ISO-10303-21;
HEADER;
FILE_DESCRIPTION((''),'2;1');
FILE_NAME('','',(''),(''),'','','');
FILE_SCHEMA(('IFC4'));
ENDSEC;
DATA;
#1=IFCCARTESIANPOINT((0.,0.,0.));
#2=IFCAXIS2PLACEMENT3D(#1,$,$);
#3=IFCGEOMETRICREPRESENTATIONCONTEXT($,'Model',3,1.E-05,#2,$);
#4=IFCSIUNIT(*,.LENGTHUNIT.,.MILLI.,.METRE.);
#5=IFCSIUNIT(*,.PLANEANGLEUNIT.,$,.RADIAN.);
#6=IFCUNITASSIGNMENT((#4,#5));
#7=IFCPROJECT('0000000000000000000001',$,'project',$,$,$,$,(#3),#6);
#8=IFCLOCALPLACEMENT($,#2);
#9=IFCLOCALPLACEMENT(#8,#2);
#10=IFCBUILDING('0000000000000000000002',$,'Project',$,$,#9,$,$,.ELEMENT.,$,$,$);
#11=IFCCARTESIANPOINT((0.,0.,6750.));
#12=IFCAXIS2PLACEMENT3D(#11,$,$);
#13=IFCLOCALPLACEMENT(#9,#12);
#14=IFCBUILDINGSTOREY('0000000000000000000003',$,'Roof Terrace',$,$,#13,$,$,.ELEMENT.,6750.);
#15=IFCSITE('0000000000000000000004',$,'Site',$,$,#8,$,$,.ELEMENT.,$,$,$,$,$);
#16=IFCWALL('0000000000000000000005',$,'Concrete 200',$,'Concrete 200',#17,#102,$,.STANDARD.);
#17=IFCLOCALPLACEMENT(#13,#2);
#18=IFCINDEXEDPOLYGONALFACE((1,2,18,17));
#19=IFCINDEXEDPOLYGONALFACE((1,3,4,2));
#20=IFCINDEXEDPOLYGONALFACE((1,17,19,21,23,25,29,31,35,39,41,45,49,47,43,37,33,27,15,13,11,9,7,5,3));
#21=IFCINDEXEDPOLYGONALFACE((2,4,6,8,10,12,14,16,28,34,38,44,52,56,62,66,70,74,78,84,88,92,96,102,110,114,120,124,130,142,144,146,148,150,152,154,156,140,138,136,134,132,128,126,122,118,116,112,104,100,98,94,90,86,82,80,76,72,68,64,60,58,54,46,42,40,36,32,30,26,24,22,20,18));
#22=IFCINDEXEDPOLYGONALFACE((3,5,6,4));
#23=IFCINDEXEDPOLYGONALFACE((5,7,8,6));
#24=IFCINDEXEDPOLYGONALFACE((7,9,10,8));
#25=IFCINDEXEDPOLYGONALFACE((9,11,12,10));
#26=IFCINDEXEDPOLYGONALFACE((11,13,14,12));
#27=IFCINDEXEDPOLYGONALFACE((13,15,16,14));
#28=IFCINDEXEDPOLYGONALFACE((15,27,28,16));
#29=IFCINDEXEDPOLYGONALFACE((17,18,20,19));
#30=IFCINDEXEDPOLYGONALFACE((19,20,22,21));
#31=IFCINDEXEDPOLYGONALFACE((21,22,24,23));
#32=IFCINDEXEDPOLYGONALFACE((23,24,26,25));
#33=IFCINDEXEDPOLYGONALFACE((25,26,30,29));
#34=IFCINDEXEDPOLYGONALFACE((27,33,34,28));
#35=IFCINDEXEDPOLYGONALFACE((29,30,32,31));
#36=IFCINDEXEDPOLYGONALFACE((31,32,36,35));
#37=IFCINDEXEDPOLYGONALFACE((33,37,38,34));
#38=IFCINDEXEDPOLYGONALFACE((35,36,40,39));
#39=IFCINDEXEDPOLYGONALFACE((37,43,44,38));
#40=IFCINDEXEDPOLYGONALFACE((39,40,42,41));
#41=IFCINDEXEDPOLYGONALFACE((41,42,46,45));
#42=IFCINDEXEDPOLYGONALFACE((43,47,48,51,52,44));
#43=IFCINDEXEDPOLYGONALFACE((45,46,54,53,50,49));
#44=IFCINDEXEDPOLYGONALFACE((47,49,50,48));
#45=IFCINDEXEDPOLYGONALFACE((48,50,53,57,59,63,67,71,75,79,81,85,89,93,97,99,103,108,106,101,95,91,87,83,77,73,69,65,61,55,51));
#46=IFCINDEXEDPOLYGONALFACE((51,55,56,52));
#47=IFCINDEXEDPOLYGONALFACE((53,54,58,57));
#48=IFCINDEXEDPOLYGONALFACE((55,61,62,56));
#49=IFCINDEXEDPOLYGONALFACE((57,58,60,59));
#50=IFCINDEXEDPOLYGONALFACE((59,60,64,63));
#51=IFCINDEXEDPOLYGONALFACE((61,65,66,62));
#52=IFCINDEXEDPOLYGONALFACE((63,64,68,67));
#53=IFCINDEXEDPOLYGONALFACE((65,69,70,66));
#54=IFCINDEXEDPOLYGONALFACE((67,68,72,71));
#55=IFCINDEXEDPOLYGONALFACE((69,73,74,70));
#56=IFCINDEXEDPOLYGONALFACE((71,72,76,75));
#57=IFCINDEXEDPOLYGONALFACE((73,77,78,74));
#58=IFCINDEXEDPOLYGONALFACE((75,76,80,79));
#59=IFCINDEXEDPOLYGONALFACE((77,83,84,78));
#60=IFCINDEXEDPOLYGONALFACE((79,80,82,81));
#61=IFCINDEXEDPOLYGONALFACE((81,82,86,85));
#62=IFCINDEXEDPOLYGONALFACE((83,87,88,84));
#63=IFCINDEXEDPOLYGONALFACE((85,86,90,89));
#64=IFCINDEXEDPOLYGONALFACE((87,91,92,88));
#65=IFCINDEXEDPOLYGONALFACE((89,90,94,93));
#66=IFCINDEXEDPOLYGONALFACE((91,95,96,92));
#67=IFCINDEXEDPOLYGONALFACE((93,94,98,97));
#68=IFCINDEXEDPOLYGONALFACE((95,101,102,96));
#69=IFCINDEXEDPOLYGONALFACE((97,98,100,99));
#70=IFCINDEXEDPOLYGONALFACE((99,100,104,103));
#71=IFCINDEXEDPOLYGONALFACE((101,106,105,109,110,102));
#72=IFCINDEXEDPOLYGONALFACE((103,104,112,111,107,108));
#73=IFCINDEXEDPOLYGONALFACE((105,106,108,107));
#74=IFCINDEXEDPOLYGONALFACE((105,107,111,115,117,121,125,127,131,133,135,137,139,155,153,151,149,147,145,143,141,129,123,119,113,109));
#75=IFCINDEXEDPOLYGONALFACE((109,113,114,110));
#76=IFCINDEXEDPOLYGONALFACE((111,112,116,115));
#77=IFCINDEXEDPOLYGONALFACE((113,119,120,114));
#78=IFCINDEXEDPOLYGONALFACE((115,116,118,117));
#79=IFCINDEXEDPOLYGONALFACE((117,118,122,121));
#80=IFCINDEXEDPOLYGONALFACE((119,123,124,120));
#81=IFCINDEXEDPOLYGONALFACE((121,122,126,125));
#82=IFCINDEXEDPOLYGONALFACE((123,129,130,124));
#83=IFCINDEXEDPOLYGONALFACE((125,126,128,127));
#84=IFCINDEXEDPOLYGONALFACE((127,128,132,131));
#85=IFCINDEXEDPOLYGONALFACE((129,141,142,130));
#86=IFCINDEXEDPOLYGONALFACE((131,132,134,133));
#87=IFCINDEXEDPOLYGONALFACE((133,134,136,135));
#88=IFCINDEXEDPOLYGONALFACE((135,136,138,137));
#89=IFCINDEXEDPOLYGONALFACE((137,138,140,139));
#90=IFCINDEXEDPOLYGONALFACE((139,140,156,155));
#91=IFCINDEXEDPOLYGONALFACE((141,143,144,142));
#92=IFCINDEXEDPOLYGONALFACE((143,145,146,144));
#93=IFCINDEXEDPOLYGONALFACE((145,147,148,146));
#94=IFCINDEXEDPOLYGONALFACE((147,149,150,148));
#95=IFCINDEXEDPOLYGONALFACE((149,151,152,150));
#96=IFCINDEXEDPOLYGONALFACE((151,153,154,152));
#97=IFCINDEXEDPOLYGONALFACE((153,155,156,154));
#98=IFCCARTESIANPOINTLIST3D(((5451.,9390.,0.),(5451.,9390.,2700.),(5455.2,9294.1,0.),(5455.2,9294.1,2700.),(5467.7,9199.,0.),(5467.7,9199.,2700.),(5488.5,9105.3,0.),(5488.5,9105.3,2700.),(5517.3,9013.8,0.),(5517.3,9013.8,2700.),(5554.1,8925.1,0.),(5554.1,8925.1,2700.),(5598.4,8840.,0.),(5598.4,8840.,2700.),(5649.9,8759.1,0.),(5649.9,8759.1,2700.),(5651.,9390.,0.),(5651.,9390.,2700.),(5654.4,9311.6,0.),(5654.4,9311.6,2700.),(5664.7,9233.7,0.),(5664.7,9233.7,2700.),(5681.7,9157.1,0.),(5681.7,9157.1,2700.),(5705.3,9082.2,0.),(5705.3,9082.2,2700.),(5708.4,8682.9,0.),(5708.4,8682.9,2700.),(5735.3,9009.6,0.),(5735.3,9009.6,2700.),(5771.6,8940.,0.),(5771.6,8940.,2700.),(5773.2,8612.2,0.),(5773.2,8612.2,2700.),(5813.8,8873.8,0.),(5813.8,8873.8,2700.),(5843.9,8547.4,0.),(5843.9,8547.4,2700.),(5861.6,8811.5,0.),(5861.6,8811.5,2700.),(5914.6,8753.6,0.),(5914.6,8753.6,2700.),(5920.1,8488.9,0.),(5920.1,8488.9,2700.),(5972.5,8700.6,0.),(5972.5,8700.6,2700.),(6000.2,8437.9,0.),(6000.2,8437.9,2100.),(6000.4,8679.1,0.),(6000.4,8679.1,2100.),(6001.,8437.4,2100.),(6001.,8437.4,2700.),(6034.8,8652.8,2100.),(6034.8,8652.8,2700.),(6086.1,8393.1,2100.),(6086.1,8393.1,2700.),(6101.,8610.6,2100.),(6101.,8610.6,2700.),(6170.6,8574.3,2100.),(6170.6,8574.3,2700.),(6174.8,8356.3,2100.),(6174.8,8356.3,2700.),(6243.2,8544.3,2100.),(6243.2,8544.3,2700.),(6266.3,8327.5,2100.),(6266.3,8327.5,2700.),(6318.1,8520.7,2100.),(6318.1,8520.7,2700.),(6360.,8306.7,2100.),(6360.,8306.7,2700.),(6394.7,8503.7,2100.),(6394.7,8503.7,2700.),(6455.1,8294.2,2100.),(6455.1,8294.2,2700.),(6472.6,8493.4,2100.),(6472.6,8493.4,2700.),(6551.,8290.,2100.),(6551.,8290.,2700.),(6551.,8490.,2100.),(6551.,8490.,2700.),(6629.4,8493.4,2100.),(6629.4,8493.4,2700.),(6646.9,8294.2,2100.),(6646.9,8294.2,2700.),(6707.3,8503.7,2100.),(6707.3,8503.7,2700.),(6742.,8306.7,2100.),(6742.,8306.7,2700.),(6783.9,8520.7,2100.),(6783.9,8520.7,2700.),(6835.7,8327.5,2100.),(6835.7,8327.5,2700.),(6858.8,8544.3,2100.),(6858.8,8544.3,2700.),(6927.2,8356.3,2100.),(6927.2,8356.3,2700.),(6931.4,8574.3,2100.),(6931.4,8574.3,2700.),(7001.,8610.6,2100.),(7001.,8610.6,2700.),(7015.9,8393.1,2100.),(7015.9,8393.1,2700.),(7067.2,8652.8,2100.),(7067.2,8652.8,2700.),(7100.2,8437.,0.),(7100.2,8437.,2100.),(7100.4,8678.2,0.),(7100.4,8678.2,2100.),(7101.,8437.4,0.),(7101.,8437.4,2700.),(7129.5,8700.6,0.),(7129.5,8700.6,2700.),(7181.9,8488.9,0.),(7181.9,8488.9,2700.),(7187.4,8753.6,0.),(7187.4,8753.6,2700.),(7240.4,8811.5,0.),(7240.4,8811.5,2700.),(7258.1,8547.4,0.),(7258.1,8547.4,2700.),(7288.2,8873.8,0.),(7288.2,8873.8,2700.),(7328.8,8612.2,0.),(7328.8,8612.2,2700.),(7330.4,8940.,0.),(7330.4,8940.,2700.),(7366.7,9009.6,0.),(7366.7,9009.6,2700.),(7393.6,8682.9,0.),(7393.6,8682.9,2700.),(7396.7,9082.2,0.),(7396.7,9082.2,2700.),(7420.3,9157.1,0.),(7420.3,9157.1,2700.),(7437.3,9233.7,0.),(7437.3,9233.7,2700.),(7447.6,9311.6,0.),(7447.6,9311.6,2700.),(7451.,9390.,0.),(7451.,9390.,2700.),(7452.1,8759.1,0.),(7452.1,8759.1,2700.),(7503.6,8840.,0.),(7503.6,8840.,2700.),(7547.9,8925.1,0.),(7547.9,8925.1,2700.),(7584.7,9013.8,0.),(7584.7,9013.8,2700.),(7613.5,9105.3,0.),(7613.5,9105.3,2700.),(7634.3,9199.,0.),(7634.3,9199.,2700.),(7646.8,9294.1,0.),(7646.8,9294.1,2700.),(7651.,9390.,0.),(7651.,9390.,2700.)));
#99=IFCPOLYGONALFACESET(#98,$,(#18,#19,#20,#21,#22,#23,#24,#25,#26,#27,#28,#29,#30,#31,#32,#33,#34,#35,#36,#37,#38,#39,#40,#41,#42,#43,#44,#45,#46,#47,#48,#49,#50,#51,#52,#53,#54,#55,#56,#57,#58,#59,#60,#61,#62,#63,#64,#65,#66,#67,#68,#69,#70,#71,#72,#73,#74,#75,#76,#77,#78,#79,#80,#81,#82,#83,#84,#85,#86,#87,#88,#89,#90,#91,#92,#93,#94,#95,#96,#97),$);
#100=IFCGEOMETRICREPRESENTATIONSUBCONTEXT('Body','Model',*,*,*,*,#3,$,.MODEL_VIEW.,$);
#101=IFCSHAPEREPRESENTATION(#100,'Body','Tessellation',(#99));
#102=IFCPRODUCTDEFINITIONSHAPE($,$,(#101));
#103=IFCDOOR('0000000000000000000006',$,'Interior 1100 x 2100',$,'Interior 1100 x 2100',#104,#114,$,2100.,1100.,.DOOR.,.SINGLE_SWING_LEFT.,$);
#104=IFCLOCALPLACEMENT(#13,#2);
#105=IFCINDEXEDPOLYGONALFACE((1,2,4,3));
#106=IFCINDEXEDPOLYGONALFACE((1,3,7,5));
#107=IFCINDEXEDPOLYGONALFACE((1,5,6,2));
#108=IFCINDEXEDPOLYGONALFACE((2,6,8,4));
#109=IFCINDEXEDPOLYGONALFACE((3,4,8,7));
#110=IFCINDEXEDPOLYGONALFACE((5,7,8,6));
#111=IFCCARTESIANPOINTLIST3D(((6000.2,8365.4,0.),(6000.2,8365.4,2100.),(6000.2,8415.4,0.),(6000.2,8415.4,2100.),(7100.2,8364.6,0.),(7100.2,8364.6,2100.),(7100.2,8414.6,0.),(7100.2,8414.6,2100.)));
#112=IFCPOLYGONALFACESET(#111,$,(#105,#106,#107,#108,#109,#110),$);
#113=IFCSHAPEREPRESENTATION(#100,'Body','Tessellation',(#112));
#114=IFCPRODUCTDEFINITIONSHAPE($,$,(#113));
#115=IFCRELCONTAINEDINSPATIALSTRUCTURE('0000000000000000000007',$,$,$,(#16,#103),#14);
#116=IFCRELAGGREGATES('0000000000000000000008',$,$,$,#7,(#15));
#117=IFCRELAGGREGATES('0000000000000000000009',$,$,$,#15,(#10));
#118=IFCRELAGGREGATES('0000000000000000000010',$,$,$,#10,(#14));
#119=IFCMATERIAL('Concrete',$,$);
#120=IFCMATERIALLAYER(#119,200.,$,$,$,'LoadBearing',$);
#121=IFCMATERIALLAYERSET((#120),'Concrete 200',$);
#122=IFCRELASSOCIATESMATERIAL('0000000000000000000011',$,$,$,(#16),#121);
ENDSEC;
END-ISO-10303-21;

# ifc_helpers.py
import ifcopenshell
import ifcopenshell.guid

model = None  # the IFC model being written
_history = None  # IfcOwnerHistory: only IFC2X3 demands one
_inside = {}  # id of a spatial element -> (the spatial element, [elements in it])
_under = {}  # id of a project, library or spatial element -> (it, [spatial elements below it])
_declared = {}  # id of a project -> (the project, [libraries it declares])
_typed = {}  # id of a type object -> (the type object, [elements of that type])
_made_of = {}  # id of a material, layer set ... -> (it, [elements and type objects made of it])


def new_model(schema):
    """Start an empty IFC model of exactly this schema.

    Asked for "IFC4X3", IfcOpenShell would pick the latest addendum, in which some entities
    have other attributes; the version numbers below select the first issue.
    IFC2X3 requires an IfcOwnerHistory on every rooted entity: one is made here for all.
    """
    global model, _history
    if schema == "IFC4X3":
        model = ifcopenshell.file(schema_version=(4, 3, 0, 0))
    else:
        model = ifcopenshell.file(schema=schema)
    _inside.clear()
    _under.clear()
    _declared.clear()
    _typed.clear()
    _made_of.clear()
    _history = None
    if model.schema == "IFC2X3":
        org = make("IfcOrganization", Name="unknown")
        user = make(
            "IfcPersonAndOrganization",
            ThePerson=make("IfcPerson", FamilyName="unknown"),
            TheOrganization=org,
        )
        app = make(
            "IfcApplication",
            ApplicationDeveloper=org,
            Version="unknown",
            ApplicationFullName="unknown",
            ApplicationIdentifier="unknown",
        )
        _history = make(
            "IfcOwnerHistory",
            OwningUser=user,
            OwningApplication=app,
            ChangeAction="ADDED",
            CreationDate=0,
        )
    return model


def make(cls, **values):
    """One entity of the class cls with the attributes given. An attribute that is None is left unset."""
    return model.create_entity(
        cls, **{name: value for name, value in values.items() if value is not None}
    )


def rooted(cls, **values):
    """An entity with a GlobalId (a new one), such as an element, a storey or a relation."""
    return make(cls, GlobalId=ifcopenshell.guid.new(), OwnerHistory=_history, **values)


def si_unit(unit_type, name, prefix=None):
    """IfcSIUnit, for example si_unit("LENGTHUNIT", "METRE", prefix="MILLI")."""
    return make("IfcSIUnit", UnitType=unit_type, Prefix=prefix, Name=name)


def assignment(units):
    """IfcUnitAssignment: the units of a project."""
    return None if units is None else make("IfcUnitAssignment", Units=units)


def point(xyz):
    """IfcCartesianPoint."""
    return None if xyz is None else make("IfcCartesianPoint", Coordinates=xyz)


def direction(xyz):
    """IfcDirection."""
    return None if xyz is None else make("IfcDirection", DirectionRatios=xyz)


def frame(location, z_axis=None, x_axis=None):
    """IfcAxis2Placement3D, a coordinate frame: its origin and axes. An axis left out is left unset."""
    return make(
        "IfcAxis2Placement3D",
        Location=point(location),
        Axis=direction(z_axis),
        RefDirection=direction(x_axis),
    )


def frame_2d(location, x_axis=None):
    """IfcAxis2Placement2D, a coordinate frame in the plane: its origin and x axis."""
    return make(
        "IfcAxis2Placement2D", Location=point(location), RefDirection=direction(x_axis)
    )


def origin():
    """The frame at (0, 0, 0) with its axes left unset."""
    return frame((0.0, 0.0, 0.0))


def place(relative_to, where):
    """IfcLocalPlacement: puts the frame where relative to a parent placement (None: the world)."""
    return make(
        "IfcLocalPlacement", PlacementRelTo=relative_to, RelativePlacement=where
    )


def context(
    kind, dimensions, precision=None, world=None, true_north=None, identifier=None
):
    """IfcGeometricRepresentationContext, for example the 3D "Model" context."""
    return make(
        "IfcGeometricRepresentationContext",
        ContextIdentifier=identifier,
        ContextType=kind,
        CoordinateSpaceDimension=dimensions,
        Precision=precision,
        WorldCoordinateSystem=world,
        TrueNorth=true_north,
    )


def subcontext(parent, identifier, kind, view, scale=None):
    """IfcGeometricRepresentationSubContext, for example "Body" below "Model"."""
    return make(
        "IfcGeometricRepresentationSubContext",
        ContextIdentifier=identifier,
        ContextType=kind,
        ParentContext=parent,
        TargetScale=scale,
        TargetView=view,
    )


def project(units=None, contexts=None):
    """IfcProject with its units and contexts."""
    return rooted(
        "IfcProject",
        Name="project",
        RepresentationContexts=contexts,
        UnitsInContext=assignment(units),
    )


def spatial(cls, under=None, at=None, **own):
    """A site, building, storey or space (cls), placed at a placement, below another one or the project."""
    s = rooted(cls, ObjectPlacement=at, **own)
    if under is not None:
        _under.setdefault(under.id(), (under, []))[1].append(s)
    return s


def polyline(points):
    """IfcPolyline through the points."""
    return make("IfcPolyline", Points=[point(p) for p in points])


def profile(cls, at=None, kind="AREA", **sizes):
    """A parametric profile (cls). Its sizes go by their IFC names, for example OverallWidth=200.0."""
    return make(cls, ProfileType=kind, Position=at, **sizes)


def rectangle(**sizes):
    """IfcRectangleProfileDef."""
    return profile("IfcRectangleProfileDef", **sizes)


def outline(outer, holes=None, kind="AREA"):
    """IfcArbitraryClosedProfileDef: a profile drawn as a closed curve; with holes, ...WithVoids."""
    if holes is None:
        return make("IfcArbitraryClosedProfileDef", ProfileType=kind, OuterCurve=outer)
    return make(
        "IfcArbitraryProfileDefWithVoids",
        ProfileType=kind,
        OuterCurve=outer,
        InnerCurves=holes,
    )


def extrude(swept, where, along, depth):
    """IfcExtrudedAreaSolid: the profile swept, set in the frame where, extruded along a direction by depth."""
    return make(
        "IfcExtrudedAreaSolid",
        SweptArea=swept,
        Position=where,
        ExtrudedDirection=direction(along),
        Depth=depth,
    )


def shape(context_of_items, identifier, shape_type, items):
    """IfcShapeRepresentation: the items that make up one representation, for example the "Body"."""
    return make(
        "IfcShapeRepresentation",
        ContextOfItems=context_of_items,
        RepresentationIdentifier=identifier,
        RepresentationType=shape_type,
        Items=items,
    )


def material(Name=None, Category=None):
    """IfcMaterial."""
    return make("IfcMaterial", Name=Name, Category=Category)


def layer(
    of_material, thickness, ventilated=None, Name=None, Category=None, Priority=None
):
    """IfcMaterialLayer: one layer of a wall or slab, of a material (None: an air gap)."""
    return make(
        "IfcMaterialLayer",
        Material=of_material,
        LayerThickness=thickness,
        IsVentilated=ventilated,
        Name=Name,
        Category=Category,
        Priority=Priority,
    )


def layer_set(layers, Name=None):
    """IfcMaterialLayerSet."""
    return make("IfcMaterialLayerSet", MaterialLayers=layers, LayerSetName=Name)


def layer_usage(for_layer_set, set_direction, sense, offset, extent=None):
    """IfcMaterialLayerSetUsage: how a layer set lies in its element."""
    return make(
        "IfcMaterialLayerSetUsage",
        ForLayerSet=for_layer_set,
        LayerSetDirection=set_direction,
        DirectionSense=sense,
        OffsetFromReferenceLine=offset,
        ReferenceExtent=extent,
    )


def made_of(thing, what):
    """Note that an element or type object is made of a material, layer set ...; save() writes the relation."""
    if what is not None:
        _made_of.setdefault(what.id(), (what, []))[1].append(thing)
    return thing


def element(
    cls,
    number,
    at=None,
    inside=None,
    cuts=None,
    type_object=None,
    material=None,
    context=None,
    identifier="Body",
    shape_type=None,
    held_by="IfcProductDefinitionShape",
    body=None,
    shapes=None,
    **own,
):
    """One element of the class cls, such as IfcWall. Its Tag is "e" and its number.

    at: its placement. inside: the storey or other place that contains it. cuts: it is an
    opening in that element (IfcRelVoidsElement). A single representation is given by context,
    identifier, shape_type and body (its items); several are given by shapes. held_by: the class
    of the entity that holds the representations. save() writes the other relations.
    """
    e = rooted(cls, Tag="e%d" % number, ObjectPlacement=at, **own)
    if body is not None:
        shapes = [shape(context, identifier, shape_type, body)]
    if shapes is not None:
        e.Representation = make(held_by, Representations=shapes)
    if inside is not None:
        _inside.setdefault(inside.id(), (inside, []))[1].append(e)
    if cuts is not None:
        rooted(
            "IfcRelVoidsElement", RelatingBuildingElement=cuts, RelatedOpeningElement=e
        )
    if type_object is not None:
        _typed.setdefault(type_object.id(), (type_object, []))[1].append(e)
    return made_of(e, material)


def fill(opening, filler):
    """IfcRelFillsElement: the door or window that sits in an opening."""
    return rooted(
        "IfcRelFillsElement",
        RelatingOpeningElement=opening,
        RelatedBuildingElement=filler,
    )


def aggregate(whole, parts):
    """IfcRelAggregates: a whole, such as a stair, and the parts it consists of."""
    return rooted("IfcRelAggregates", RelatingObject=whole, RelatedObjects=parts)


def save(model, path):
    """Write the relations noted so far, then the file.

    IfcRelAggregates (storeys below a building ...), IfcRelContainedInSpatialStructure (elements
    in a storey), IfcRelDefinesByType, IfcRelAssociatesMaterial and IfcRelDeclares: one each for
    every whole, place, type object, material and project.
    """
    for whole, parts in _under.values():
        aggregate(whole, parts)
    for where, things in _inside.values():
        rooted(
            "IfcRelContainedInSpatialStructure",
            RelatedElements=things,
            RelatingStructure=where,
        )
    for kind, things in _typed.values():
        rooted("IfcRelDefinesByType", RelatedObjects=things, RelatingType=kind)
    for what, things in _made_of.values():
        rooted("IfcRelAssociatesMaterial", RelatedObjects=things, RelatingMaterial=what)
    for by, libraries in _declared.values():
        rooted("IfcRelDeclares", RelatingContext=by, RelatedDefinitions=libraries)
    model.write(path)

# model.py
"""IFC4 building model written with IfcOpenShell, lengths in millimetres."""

from ifc_helpers import new_model, si_unit, frame, frame_2d, origin, place, context, subcontext, project, spatial, polyline, rectangle, outline, extrude, material, layer, layer_set, layer_usage, element, fill, save


model = new_model("IFC4")

# Units and contexts
model_context = context("Model", 3, precision=1e-05, world=origin())
body_context = subcontext(model_context, "Body", "Model", "MODEL_VIEW")
ifc_project = project(units=[si_unit("LENGTHUNIT", "METRE", prefix="MILLI"), si_unit("PLANEANGLEUNIT", "RADIAN")], contexts=[model_context])

# Site, building, storey
site_placement = place(None, origin())
site = spatial("IfcSite", under=ifc_project, at=site_placement, Name="Site", CompositionType="ELEMENT")
building_placement = place(site_placement, origin())
building = spatial("IfcBuilding", under=site, at=building_placement, Name="Project", CompositionType="ELEMENT")
storey_placement = place(building_placement, frame((0.0, 0.0, 6750.0)))
storey = spatial("IfcBuildingStorey", under=building, at=storey_placement, Name="Roof Terrace", CompositionType="ELEMENT", Elevation=6750.0)

# Shared definitions
ifc_material = material(Name="Concrete")

# Shared definitions
ifc_layer_1 = layer(ifc_material, 200.0, Category="LoadBearing")
ifc_layer_set_1 = layer_set([ifc_layer_1], Name="Concrete 200")
ifc_layer_usage_1 = layer_usage(ifc_layer_set_1, "AXIS2", "NEGATIVE", 100.0)

# Wall, opening, door
wall_1_placement = place(storey_placement, frame((5551.0, 9390.0, 0.0), z_axis=(0.0, 0.0, 1.0), x_axis=(0.0, -1.0, 0.0)))
wall_1 = element("IfcWall", 1, at=wall_1_placement, inside=storey, material=ifc_layer_usage_1, Name="Concrete 200", ObjectType="Concrete 200", PredefinedType="STANDARD", context=body_context, shape_type="SweptSolid", body=[
    extrude(outline(polyline([(0.0, -100.0), (0.0, 0.0), (0.0, 100.0), (78.4, 103.4), (156.3, 113.7), (232.9, 130.7), (307.8, 154.3), (380.4, 184.3), (450.0, 220.6), (516.2, 262.8), (578.5, 310.6), (636.4, 363.6), (689.4, 421.5), (737.2, 483.8), (779.4, 550.0), (815.7, 619.6), (845.7, 692.2), (869.3, 767.1), (886.3, 843.7), (896.6, 921.6), (900.0, 1000.0), (896.6, 1078.4), (886.3, 1156.3), (869.3, 1232.9), (845.7, 1307.8), (815.7, 1380.4), (779.4, 1450.0), (737.2, 1516.2), (689.4, 1578.5), (636.4, 1636.4), (578.5, 1689.4), (516.2, 1737.2), (450.0, 1779.4), (380.4, 1815.7), (307.8, 1845.7), (232.9, 1869.3), (156.3, 1886.3), (78.4, 1896.6), (0.0, 1900.0), (0.0, 2000.0), (0.0, 2100.0), (95.9, 2095.8), (191.0, 2083.3), (284.7, 2062.5), (376.2, 2033.7), (464.9, 1996.9), (550.0, 1952.6), (630.9, 1901.1), (707.1, 1842.6), (777.8, 1777.8), (842.6, 1707.1), (901.1, 1630.9), (952.6, 1550.0), (996.9, 1464.9), (1033.7, 1376.2), (1062.5, 1284.7), (1083.3, 1191.0), (1095.8, 1095.9), (1100.0, 1000.0), (1095.8, 904.1), (1083.3, 809.0), (1062.5, 715.3), (1033.7, 623.8), (996.9, 535.1), (952.6, 450.0), (901.1, 369.1), (842.6, 292.9), (777.8, 222.2), (707.1, 157.4), (630.9, 98.9), (550.0, 47.4), (464.9, 3.1), (376.2, -33.7), (284.7, -62.5), (191.0, -83.3), (95.9, -95.8), (0.0, -100.0)])), origin(), (0.0, 0.0, 1.0), 2700.0),
])
opening_placement = place(wall_1_placement, frame((999.6, 449.2, 0.0), z_axis=(0.0, 0.0, 1.0), x_axis=(0.000796, 1.0, 0.0)))
opening = element("IfcOpeningElement", 2, at=opening_placement, cuts=wall_1, PredefinedType="OPENING", context=body_context, shape_type="SweptSolid", body=[
    extrude(rectangle(XDim=1100.0, YDim=595.2, at=frame_2d((550.0, 0.0))), origin(), (0.0, 0.0, 1.0), 2100.0),
])
door_placement = place(opening_placement, origin())
door = element("IfcDoor", 3, at=door_placement, inside=storey, Name="Interior 1100 x 2100", ObjectType="Interior 1100 x 2100", OperationType="SINGLE_SWING_LEFT", OverallHeight=2100.0, OverallWidth=1100.0, PredefinedType="DOOR", context=body_context, shape_type="SweptSolid", body=[
    extrude(rectangle(XDim=1100.0, YDim=50.0, at=frame_2d((550.0, 0.0))), origin(), (0.0, 0.0, 1.0), 2100.0),
])
fill(opening, door)

save(model, "model.ifc")
